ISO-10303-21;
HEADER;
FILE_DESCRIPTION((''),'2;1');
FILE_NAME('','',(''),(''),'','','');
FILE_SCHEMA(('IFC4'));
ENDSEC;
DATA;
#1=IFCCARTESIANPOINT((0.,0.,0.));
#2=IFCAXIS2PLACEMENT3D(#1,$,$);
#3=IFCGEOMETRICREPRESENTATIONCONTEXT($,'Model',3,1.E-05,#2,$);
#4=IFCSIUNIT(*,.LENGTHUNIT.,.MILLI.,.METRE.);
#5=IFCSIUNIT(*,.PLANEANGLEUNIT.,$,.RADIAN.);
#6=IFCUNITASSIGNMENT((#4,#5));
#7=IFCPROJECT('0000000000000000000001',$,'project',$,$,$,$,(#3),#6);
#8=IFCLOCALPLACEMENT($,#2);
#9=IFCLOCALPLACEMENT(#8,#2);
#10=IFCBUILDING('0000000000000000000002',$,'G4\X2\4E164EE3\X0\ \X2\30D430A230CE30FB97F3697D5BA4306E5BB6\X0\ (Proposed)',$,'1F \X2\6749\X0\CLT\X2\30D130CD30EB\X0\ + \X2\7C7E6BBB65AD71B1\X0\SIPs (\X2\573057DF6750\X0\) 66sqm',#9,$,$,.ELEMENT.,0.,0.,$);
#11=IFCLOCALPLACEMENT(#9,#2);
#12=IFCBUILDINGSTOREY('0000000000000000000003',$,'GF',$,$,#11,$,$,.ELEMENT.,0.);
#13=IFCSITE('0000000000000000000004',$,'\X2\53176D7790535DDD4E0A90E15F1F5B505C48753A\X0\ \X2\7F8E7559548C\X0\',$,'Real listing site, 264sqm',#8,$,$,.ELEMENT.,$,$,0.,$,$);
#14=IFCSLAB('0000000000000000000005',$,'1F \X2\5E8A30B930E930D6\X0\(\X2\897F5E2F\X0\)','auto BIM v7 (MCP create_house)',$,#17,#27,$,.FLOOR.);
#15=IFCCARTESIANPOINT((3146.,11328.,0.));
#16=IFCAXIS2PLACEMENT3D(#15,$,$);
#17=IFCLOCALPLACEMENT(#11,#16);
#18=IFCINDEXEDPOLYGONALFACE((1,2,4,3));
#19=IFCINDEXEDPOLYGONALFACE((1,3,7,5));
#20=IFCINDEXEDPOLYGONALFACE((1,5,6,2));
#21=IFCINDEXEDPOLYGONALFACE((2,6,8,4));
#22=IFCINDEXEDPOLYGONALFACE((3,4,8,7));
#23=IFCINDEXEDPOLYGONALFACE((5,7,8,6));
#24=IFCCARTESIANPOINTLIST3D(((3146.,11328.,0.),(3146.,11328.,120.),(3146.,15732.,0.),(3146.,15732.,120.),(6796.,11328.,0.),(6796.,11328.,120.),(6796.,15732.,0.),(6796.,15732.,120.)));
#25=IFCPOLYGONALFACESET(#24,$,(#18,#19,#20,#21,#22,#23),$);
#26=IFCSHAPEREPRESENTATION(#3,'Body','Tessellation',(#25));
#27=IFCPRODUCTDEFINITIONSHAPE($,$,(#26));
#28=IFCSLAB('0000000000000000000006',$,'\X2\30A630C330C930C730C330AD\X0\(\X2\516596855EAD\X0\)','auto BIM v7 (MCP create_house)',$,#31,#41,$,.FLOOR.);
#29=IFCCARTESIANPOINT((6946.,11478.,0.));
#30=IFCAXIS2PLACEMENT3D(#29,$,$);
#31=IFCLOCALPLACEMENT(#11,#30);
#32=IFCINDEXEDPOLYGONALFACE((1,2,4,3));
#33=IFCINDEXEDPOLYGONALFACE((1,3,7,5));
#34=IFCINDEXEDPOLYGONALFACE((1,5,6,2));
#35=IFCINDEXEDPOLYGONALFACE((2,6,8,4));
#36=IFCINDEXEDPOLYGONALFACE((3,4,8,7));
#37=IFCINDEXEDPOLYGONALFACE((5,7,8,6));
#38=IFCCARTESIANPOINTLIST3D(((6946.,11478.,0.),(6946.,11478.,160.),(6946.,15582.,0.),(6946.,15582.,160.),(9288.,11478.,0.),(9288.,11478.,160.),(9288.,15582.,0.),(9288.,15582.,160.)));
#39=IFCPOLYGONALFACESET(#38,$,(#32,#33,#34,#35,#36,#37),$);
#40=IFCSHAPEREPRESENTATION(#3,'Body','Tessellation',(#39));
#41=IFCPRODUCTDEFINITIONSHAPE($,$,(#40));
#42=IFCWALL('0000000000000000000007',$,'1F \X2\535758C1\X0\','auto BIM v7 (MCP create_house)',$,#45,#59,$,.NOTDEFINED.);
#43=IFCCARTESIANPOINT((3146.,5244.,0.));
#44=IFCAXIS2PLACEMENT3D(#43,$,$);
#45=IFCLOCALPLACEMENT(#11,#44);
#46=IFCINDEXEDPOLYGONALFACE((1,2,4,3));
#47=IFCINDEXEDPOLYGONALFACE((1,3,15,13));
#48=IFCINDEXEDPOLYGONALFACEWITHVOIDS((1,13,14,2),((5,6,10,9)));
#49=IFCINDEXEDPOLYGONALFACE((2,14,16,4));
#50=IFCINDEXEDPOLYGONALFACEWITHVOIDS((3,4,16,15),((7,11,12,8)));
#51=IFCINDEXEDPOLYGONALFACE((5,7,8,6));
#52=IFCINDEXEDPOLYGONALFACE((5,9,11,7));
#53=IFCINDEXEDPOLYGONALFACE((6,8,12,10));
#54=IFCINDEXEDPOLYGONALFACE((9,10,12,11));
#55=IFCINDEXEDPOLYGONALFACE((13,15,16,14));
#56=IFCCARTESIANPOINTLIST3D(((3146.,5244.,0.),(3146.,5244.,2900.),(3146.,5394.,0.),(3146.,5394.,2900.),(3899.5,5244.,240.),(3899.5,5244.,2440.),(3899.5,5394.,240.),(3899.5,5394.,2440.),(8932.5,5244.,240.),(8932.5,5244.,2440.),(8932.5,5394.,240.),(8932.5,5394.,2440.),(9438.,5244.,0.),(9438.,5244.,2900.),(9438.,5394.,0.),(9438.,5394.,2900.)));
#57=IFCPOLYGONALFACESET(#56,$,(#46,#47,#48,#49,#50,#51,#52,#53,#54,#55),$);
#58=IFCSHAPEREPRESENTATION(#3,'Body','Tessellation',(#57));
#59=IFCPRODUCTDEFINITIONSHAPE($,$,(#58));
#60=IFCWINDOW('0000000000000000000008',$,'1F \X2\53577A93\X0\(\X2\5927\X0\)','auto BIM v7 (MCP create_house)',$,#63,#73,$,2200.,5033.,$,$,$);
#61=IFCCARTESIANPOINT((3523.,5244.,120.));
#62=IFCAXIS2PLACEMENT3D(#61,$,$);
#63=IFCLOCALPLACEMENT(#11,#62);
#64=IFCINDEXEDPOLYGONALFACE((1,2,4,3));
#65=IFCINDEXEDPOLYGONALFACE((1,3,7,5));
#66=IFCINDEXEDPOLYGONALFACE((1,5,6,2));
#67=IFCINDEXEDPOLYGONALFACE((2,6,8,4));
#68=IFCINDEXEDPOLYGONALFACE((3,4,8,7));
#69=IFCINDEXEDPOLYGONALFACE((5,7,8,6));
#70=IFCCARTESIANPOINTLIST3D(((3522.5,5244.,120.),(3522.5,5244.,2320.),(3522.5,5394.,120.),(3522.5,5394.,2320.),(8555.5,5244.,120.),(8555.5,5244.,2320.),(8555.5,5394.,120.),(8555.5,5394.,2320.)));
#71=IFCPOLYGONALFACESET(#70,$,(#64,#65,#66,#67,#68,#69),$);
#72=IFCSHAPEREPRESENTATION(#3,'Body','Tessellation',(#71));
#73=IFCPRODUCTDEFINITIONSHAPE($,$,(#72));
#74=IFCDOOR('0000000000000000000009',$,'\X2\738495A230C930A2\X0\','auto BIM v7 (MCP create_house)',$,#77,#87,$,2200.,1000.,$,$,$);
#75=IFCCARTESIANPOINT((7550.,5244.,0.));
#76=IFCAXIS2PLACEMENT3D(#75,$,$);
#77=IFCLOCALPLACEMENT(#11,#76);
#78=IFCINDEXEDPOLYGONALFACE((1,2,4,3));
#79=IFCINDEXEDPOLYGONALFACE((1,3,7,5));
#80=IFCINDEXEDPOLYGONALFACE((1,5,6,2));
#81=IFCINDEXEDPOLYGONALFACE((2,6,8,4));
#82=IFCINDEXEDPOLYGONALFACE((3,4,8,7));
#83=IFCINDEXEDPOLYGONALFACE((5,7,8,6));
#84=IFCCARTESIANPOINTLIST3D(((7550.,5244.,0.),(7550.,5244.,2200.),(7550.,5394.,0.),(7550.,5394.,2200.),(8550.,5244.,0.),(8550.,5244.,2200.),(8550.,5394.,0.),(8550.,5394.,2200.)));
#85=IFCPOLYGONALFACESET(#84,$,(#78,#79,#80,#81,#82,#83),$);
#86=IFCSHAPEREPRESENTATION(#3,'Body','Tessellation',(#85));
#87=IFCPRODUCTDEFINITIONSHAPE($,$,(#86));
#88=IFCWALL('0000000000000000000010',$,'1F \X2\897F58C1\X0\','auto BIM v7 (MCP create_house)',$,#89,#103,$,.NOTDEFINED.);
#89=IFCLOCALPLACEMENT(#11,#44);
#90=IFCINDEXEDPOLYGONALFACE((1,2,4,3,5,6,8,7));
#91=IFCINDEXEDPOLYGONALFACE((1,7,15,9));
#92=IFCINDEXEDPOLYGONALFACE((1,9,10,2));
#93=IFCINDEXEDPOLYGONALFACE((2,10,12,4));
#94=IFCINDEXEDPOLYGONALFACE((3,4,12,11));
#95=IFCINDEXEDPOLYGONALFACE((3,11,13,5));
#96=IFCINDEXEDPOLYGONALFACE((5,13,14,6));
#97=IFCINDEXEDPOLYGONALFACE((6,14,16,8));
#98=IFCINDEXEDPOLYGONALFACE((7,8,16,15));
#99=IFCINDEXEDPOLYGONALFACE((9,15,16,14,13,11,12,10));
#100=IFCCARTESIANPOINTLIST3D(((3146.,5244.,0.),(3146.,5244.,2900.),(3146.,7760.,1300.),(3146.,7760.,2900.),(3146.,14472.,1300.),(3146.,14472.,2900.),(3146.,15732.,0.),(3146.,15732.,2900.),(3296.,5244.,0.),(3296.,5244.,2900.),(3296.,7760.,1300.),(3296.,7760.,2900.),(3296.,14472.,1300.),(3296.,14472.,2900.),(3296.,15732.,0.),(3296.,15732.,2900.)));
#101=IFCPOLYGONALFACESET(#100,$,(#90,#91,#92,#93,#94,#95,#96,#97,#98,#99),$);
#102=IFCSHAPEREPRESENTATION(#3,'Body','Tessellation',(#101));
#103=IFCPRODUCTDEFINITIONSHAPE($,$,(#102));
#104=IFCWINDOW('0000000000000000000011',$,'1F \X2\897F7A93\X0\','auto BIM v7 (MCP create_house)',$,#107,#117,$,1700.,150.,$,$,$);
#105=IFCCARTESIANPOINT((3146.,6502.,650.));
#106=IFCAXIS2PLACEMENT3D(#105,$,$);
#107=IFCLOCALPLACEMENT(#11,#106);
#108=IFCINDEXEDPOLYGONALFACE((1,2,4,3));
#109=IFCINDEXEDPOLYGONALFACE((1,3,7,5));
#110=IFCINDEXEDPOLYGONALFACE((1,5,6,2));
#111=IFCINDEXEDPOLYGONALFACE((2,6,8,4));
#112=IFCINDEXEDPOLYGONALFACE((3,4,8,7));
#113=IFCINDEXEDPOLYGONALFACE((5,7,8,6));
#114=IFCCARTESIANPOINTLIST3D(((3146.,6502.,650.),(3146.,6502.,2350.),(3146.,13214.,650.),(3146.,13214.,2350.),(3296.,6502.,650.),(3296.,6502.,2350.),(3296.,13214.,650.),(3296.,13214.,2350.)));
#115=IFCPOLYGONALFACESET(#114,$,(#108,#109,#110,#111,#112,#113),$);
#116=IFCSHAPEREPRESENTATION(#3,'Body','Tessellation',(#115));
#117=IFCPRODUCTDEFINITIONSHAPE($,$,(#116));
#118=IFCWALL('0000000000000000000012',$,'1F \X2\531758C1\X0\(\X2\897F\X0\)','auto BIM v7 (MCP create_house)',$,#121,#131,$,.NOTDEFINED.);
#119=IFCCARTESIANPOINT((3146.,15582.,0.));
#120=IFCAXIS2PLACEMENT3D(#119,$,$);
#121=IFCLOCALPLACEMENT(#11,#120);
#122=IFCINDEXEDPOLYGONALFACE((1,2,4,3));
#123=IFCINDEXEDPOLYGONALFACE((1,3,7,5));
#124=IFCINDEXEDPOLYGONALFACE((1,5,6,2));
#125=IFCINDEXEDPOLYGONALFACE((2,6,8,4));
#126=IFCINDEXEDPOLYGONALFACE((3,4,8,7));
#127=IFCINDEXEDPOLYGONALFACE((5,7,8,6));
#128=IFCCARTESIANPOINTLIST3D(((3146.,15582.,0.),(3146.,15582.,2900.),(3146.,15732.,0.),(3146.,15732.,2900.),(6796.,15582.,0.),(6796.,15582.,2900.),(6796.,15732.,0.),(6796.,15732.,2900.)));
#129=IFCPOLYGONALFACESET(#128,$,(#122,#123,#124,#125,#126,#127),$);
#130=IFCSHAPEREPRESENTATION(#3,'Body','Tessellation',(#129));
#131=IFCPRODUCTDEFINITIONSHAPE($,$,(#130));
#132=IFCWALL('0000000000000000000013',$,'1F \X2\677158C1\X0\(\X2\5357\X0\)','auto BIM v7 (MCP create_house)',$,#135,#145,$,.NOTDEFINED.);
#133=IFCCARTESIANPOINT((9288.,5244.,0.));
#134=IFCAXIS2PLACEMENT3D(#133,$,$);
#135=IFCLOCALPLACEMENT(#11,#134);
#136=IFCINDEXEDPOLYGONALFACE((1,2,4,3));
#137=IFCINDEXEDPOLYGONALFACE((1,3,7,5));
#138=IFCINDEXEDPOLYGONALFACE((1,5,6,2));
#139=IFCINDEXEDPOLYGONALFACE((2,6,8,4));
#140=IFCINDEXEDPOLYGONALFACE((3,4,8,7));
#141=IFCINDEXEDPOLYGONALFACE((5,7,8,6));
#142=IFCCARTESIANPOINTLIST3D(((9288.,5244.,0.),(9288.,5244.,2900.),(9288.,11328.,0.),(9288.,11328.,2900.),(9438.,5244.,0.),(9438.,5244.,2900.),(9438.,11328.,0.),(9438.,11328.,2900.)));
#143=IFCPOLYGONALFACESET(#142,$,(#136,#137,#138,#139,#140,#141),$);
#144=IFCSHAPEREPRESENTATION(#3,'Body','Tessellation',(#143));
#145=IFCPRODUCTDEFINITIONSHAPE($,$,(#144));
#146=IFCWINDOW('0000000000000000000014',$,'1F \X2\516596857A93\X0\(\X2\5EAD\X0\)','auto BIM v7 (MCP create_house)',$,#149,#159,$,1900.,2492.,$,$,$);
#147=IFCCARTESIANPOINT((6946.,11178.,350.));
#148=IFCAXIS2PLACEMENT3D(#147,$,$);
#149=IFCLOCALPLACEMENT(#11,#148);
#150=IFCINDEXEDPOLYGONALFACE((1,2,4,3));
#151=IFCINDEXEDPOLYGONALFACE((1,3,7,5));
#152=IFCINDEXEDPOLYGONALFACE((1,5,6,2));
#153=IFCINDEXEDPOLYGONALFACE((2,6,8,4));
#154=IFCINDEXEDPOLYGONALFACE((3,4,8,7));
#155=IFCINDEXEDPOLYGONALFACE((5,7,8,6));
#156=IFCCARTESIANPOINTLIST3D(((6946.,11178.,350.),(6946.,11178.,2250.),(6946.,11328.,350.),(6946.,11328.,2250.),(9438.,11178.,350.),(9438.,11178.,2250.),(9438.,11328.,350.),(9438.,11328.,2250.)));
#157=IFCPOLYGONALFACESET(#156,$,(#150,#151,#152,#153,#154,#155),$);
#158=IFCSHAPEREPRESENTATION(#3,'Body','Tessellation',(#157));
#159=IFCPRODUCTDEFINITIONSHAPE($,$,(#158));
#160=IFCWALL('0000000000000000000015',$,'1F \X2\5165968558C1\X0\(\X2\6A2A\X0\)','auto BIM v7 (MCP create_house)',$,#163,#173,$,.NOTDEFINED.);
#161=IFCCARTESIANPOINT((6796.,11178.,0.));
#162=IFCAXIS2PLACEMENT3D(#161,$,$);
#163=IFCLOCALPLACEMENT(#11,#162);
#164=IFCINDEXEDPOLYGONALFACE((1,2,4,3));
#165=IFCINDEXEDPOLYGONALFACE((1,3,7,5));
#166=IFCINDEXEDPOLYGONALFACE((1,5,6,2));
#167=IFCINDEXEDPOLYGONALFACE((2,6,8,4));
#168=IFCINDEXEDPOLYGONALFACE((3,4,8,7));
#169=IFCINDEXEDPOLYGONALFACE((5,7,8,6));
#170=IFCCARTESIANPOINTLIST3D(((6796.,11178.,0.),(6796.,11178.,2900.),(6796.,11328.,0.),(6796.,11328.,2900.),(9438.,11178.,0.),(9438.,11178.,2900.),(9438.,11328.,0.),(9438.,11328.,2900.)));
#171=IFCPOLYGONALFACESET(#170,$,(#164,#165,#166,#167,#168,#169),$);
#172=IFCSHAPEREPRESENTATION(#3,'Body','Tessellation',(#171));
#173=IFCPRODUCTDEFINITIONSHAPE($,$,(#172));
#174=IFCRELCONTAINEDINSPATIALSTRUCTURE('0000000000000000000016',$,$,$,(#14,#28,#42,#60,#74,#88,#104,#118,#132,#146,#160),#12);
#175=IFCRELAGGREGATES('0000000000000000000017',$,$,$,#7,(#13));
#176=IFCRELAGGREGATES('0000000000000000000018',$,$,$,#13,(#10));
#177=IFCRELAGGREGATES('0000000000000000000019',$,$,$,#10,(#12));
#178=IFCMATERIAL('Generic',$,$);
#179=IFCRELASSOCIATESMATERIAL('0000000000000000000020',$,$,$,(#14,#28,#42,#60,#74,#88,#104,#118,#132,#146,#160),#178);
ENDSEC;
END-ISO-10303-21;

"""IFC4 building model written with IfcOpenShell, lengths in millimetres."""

from ifc_helpers import new_model, si_unit, frame, frame_2d, origin, place, context, project, spatial, rectangle, extrude, material, element, fill, save


model = new_model("IFC4")

# Units and contexts
model_context = context("Model", 3, precision=1e-05, world=origin())
ifc_project = project(units=[si_unit("LENGTHUNIT", "METRE", prefix="MILLI"), si_unit("PLANEANGLEUNIT", "RADIAN")], contexts=[model_context])

# Site, building, storey
site_placement = place(None, origin())
site = spatial("IfcSite", under=ifc_project, at=site_placement, Name="北海道川上郡弟子屈町 美留和", ObjectType="Real listing site, 264sqm", CompositionType="ELEMENT", RefElevation=0.0)
building_placement = place(site_placement, origin())
building = spatial("IfcBuilding", under=site, at=building_placement, Name="G4世代 ピアノ・音楽室の家 (Proposed)", ObjectType="1F 杉CLTパネル + 籾殻断熱SIPs (地域材) 66sqm", CompositionType="ELEMENT", ElevationOfRefHeight=0.0, ElevationOfTerrain=0.0)
storey_placement = place(building_placement, origin())
storey = spatial("IfcBuildingStorey", under=building, at=storey_placement, Name="GF", CompositionType="ELEMENT", Elevation=0.0)

# Slabs
ifc_material = material(Name="Generic")
slab_1_placement = place(storey_placement, frame((3146.0, 11328.0, 0.0)))
element("IfcSlab", 1, at=slab_1_placement, inside=storey, material=ifc_material, Name="1F 床スラブ(西帯)", Description="auto BIM v7 (MCP create_house)", PredefinedType="FLOOR", context=model_context, shape_type="SweptSolid", body=[
    extrude(rectangle(XDim=3650.0, YDim=4404.0, at=frame_2d((1825.0, 2202.0))), frame((3146.0, 11328.0, 0.0)), (0.0, 0.0, 1.0), 120.0),
])
slab_2_placement = place(storey_placement, frame((6946.0, 11478.0, 0.0)))
element("IfcSlab", 2, at=slab_2_placement, inside=storey, material=ifc_material, Name="ウッドデッキ(入隅庭)", Description="auto BIM v7 (MCP create_house)", PredefinedType="FLOOR", context=model_context, shape_type="SweptSolid", body=[
    extrude(rectangle(XDim=2342.0, YDim=4104.0, at=frame_2d((1171.0, 2052.0))), frame((6946.0, 11478.0, 0.0)), (0.0, 0.0, 1.0), 160.0),
])

# Wall, openings, window, door
wall_1_placement = place(storey_placement, frame((3146.0, 5244.0, 0.0)))
wall_1 = element("IfcWall", 3, at=wall_1_placement, inside=storey, material=ifc_material, Name="1F 南壁", Description="auto BIM v7 (MCP create_house)", PredefinedType="NOTDEFINED", context=model_context, shape_type="SweptSolid", body=[
    extrude(rectangle(XDim=6292.0, YDim=150.0, at=frame_2d((3146.0, 75.0))), frame((3146.0, 5244.0, 0.0)), (0.0, 0.0, 1.0), 2900.0),
])
opening_1_placement = place(storey_placement, frame((3523.0, 5244.0, 120.0)))
opening_1 = element("IfcOpeningElement", 4, at=opening_1_placement, cuts=wall_1, PredefinedType="NOTDEFINED", context=model_context, shape_type="SweptSolid", body=[
    extrude(rectangle(XDim=5033.0, YDim=150.0, at=frame_2d((2516.0, 75.0))), frame((3523.0, 5244.0, 120.0)), (0.0, 0.0, 1.0), 2200.0),
])
opening_2_placement = place(storey_placement, frame((7550.0, 5244.0, 0.0)))
opening_2 = element("IfcOpeningElement", 5, at=opening_2_placement, cuts=wall_1, PredefinedType="NOTDEFINED", context=model_context, shape_type="SweptSolid", body=[
    extrude(rectangle(XDim=1000.0, YDim=150.0, at=frame_2d((500.0, 75.0))), frame((7550.0, 5244.0, 0.0)), (0.0, 0.0, 1.0), 2200.0),
])
window_1_placement = place(storey_placement, frame((3523.0, 5244.0, 120.0)))
window_1 = element("IfcWindow", 6, at=window_1_placement, inside=storey, material=ifc_material, Name="1F 南窓(大)", Description="auto BIM v7 (MCP create_house)", OverallHeight=2200.0, OverallWidth=5033.0, context=model_context, shape_type="SweptSolid", body=[
    extrude(rectangle(XDim=5033.0, YDim=150.0, at=frame_2d((2516.0, 75.0))), frame((3523.0, 5244.0, 120.0)), (0.0, 0.0, 1.0), 2200.0),
])
fill(opening_1, window_1)
door_placement = place(storey_placement, frame((7550.0, 5244.0, 0.0)))
door = element("IfcDoor", 7, at=door_placement, inside=storey, material=ifc_material, Name="玄関ドア", Description="auto BIM v7 (MCP create_house)", OverallHeight=2200.0, OverallWidth=1000.0, context=model_context, shape_type="SweptSolid", body=[
    extrude(rectangle(XDim=1000.0, YDim=150.0, at=frame_2d((500.0, 75.0))), frame((7550.0, 5244.0, 0.0)), (0.0, 0.0, 1.0), 2200.0),
])
fill(opening_2, door)

# Wall, opening, window
wall_2_placement = place(storey_placement, frame((3146.0, 5244.0, 0.0)))
wall_2 = element("IfcWall", 8, at=wall_2_placement, inside=storey, material=ifc_material, Name="1F 西壁", Description="auto BIM v7 (MCP create_house)", PredefinedType="NOTDEFINED", context=model_context, shape_type="SweptSolid", body=[
    extrude(rectangle(XDim=150.0, YDim=10488.0, at=frame_2d((75.0, 5244.0))), frame((3146.0, 5244.0, 0.0)), (0.0, 0.0, 1.0), 2900.0),
])
opening_3_placement = place(storey_placement, frame((3146.0, 6502.0, 650.0)))
opening_3 = element("IfcOpeningElement", 9, at=opening_3_placement, cuts=wall_2, PredefinedType="NOTDEFINED", context=model_context, shape_type="SweptSolid", body=[
    extrude(rectangle(XDim=150.0, YDim=6712.0, at=frame_2d((75.0, 3356.0))), frame((3146.0, 6502.0, 650.0)), (0.0, 0.0, 1.0), 1700.0),
])
window_2_placement = place(storey_placement, frame((3146.0, 6502.0, 650.0)))
window_2 = element("IfcWindow", 10, at=window_2_placement, inside=storey, material=ifc_material, Name="1F 西窓", Description="auto BIM v7 (MCP create_house)", OverallHeight=1700.0, OverallWidth=150.0, context=model_context, shape_type="SweptSolid", body=[
    extrude(rectangle(XDim=150.0, YDim=6712.0, at=frame_2d((75.0, 3356.0))), frame((3146.0, 6502.0, 650.0)), (0.0, 0.0, 1.0), 1700.0),
])
fill(opening_3, window_2)

# Wall
wall_3_placement = place(storey_placement, frame((3146.0, 15582.0, 0.0)))
element("IfcWall", 11, at=wall_3_placement, inside=storey, material=ifc_material, Name="1F 北壁(西)", Description="auto BIM v7 (MCP create_house)", PredefinedType="NOTDEFINED", context=model_context, shape_type="SweptSolid", body=[
    extrude(rectangle(XDim=3650.0, YDim=150.0, at=frame_2d((1825.0, 75.0))), frame((3146.0, 15582.0, 0.0)), (0.0, 0.0, 1.0), 2900.0),
])

# Wall, opening, window
wall_4_placement = place(storey_placement, frame((9288.0, 5244.0, 0.0)))
wall_4 = element("IfcWall", 12, at=wall_4_placement, inside=storey, material=ifc_material, Name="1F 東壁(南)", Description="auto BIM v7 (MCP create_house)", PredefinedType="NOTDEFINED", context=model_context, shape_type="SweptSolid", body=[
    extrude(rectangle(XDim=150.0, YDim=6084.0, at=frame_2d((75.0, 3042.0))), frame((9288.0, 5244.0, 0.0)), (0.0, 0.0, 1.0), 2900.0),
])
opening_4_placement = place(storey_placement, frame((6946.0, 11178.0, 350.0)))
opening_4 = element("IfcOpeningElement", 13, at=opening_4_placement, cuts=wall_4, PredefinedType="NOTDEFINED", context=model_context, shape_type="SweptSolid", body=[
    extrude(rectangle(XDim=2492.0, YDim=150.0, at=frame_2d((1246.0, 75.0))), frame((6946.0, 11178.0, 350.0)), (0.0, 0.0, 1.0), 1900.0),
])
window_3_placement = place(storey_placement, frame((6946.0, 11178.0, 350.0)))
window_3 = element("IfcWindow", 14, at=window_3_placement, inside=storey, material=ifc_material, Name="1F 入隅窓(庭)", Description="auto BIM v7 (MCP create_house)", OverallHeight=1900.0, OverallWidth=2492.0, context=model_context, shape_type="SweptSolid", body=[
    extrude(rectangle(XDim=2492.0, YDim=150.0, at=frame_2d((1246.0, 75.0))), frame((6946.0, 11178.0, 350.0)), (0.0, 0.0, 1.0), 1900.0),
])
fill(opening_4, window_3)

# Wall
wall_5_placement = place(storey_placement, frame((6796.0, 11178.0, 0.0)))
element("IfcWall", 15, at=wall_5_placement, inside=storey, material=ifc_material, Name="1F 入隅壁(横)", Description="auto BIM v7 (MCP create_house)", PredefinedType="NOTDEFINED", context=model_context, shape_type="SweptSolid", body=[
    extrude(rectangle(XDim=2642.0, YDim=150.0, at=frame_2d((1321.0, 75.0))), frame((6796.0, 11178.0, 0.0)), (0.0, 0.0, 1.0), 2900.0),
])

save(model, "model.ifc")
